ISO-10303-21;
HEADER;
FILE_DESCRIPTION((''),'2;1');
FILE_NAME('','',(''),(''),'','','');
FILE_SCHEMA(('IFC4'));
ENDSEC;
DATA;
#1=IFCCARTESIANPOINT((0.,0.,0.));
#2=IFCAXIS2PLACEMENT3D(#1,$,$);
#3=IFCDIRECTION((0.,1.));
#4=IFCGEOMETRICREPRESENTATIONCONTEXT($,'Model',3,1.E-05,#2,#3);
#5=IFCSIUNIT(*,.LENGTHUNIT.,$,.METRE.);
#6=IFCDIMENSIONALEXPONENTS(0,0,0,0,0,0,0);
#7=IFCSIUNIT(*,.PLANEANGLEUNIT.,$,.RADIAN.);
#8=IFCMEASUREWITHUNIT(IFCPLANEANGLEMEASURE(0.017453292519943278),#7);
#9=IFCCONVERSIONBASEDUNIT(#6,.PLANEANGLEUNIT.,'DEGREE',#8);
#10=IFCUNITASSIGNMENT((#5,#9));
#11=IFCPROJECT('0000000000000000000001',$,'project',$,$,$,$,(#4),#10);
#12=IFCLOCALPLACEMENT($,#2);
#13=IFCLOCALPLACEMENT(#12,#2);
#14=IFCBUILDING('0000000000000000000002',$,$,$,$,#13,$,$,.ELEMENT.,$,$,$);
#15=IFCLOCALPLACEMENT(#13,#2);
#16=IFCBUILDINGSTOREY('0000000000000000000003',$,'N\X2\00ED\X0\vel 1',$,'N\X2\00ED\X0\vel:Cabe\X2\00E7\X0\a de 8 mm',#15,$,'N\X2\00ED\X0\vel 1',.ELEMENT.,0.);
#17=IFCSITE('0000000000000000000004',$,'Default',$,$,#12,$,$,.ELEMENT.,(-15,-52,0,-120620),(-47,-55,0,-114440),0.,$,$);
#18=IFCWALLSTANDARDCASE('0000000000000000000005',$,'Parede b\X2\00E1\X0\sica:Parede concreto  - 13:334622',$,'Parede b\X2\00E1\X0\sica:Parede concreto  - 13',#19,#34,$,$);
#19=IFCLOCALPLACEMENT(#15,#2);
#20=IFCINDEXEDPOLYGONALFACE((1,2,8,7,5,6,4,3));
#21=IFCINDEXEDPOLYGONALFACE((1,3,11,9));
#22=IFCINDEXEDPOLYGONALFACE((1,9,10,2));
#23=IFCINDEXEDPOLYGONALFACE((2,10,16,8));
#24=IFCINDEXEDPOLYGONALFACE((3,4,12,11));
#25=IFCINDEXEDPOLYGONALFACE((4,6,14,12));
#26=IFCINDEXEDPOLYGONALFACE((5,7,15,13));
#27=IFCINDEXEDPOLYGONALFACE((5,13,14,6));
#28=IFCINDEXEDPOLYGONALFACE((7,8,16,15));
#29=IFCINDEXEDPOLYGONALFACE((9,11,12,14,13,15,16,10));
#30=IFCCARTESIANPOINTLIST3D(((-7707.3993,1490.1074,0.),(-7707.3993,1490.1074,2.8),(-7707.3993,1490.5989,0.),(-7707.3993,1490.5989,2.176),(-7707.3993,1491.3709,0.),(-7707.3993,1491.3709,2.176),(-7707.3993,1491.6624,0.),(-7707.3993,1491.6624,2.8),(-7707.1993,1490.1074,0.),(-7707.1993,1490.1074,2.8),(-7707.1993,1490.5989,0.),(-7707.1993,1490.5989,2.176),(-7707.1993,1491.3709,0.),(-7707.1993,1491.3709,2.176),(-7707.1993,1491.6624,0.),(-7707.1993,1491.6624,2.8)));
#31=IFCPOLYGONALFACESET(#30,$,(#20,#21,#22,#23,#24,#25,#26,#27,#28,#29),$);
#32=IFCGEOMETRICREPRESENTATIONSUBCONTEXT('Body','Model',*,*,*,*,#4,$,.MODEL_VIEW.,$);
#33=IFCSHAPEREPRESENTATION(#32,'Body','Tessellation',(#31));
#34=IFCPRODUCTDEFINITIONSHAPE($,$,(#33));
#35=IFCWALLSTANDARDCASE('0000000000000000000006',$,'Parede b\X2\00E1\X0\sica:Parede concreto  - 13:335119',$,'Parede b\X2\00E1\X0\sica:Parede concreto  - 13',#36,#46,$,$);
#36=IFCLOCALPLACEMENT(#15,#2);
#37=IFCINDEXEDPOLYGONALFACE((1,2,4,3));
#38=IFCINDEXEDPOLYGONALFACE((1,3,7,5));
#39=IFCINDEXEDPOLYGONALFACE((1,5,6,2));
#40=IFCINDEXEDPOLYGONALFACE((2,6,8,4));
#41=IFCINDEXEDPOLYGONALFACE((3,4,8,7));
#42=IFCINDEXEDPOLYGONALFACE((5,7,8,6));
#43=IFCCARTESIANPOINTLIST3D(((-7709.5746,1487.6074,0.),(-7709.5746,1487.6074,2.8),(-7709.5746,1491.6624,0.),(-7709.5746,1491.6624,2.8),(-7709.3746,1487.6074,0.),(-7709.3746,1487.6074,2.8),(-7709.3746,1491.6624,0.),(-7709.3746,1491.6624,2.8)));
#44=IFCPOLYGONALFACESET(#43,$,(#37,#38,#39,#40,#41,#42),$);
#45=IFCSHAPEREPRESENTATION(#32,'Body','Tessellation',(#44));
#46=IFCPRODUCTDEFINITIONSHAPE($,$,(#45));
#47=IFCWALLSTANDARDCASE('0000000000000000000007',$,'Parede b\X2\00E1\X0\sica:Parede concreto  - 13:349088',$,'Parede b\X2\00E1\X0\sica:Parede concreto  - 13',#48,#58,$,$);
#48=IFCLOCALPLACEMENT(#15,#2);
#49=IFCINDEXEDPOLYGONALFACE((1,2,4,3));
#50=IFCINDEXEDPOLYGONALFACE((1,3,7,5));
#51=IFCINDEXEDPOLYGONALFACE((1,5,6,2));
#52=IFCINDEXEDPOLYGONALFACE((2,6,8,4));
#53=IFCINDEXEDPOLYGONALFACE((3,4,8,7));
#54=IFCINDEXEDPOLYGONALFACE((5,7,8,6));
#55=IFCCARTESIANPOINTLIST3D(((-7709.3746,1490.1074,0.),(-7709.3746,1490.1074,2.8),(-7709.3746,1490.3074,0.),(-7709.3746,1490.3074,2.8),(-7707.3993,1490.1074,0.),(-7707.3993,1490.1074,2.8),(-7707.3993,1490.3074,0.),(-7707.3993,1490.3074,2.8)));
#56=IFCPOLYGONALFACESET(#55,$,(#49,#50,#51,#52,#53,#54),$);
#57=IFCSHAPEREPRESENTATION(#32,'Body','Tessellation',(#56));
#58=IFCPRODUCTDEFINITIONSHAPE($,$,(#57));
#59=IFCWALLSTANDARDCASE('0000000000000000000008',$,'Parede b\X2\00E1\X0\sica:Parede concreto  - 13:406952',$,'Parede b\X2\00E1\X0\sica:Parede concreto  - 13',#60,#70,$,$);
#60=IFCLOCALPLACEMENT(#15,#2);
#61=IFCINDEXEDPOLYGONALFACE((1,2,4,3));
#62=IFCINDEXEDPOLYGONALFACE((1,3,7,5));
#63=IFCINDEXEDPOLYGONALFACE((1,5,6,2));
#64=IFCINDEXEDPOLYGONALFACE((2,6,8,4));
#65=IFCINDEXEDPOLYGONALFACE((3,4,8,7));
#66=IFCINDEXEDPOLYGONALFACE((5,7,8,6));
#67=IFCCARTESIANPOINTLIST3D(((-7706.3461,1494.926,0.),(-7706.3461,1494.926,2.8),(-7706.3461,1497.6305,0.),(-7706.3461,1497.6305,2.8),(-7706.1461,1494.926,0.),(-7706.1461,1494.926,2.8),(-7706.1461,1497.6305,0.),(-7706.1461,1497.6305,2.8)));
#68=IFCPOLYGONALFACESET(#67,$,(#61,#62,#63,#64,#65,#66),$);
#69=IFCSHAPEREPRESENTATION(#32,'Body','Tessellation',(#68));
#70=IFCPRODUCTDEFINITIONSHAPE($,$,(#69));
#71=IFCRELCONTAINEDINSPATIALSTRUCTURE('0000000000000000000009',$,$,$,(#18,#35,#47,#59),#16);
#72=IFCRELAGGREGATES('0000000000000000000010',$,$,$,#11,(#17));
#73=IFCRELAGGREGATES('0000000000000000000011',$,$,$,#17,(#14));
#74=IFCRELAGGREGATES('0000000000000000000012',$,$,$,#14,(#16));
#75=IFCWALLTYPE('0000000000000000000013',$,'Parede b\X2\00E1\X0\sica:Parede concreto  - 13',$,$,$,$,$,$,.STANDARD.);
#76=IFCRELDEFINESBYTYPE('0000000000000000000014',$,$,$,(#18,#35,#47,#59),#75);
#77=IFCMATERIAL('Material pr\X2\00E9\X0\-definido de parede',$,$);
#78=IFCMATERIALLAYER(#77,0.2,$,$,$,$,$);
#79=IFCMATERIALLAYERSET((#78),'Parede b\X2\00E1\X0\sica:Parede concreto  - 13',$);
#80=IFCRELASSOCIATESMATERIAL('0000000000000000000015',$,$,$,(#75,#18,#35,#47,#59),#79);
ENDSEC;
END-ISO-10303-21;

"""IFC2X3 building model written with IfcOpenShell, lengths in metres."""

from ifc_helpers import new_model, entity, si_unit, converted_unit, direction, frame, frame_2d, origin, place, context, subcontext, project, spatial, rectangle, extrude, material, layer, layer_set, layer_usage, type_object, element, save


model = new_model("IFC2X3")

# Units and contexts
model_context = context("Model", 3, precision=1e-05, world=origin(), true_north=direction((0.0, 1.0)))
body_context = subcontext(model_context, "Body", "Model", "MODEL_VIEW")
ifc_project = project(units=[si_unit("LENGTHUNIT", "METRE"), converted_unit("PLANEANGLEUNIT", "DEGREE", entity("IfcPlaneAngleMeasure", 0.017453292519943278), si_unit("PLANEANGLEUNIT", "RADIAN"), dimensions=[0, 0, 0, 0, 0, 0, 0])], contexts=[model_context])

# Site, building, storey
site_placement = place(None, origin())
site = spatial("IfcSite", under=ifc_project, at=site_placement, Name="Default", CompositionType="ELEMENT", RefLatitude=(-15, -52, 0, -120620), RefLongitude=(-47, -55, 0, -114440), RefElevation=0.0)
building_placement = place(site_placement, origin())
building = spatial("IfcBuilding", under=site, at=building_placement, CompositionType="ELEMENT")
storey_placement = place(building_placement, origin())
storey = spatial("IfcBuildingStorey", under=building, at=storey_placement, Name="Nível 1", ObjectType="Nível:Cabeça de 8 mm", LongName="Nível 1", CompositionType="ELEMENT", Elevation=0.0)

# Shared definitions
ifc_material = material(Name="Material pré-definido de parede")
ifc_layer = layer(ifc_material, 0.2)
ifc_layer_set = layer_set([ifc_layer], Name="Parede básica:Parede concreto  - 13")
wall_type = type_object("IfcWallType", Name="Parede básica:Parede concreto  - 13", PredefinedType="STANDARD", material=ifc_layer_set)

# Wall, opening
ifc_layer_usage_1 = layer_usage(ifc_layer_set, "AXIS2", "POSITIVE", -0.1)
wall_1_placement = place(storey_placement, frame((-7707.2993, 1490.1074, 0.0), z_axis=(0.0, 0.0, 1.0), x_axis=(0.0, 1.0, 0.0)))
wall_1 = element("IfcWallStandardCase", 1, at=wall_1_placement, inside=storey, type_object=wall_type, material=ifc_layer_usage_1, Name="Parede básica:Parede concreto  - 13:334622", ObjectType="Parede básica:Parede concreto  - 13", context=body_context, shape_type="SweptSolid", body=[
    extrude(rectangle(XDim=1.555, YDim=0.2, at=frame_2d((0.7775, 0.0), x_axis=(-1.0, 0.0))), origin(), (0.0, 0.0, 1.0), 2.8),
])
opening_1_placement = place(wall_1_placement, origin())
element("IfcOpeningElement", 2, at=opening_1_placement, cuts=wall_1, ObjectType="Opening", context=body_context, shape_type="SweptSolid", body=[
    extrude(rectangle(XDim=2.176, YDim=0.772, at=frame_2d((0.0, 0.0), x_axis=(0.0, 1.0))), frame((0.8775, 0.1, 1.088), z_axis=(0.0, -1.0, 0.0), x_axis=(1.0, 0.0, 0.0)), (0.0, 0.0, 1.0), 0.2),
])

# Walls
ifc_layer_usage_2 = layer_usage(ifc_layer_set, "AXIS2", "POSITIVE", -0.1)
wall_2_placement = place(storey_placement, frame((-7709.4746, 1487.6074, 0.0), z_axis=(0.0, 0.0, 1.0), x_axis=(0.0, 1.0, 0.0)))
element("IfcWallStandardCase", 3, at=wall_2_placement, inside=storey, type_object=wall_type, material=ifc_layer_usage_2, Name="Parede básica:Parede concreto  - 13:335119", ObjectType="Parede básica:Parede concreto  - 13", context=body_context, shape_type="SweptSolid", body=[
    extrude(rectangle(XDim=4.055, YDim=0.2, at=frame_2d((2.0275, 0.0), x_axis=(-1.0, 0.0))), origin(), (0.0, 0.0, 1.0), 2.8),
])
ifc_layer_usage_3 = layer_usage(ifc_layer_set, "AXIS2", "NEGATIVE", 0.1)
wall_3_placement = place(storey_placement, frame((-7709.3746, 1490.2074, 0.0)))
element("IfcWallStandardCase", 4, at=wall_3_placement, inside=storey, type_object=wall_type, material=ifc_layer_usage_3, Name="Parede básica:Parede concreto  - 13:349088", ObjectType="Parede básica:Parede concreto  - 13", context=body_context, shape_type="SweptSolid", body=[
    extrude(rectangle(XDim=1.9753, YDim=0.2, at=frame_2d((0.9876, 0.0), x_axis=(-1.0, 0.0))), origin(), (0.0, 0.0, 1.0), 2.8),
])

# Wall
ifc_layer_usage_4 = layer_usage(ifc_layer_set, "AXIS2", "NEGATIVE", 0.1)
wall_4_placement = place(storey_placement, frame((-7706.2461, 1497.6305, 0.0), z_axis=(0.0, 0.0, 1.0), x_axis=(0.0, -1.0, 0.0)))
element("IfcWallStandardCase", 5, at=wall_4_placement, inside=storey, type_object=wall_type, material=ifc_layer_usage_4, Name="Parede básica:Parede concreto  - 13:406952", ObjectType="Parede básica:Parede concreto  - 13", context=body_context, shape_type="SweptSolid", body=[
    extrude(rectangle(XDim=2.7045, YDim=0.2, at=frame_2d((1.3522, 0.0), x_axis=(-1.0, 0.0))), origin(), (0.0, 0.0, 1.0), 2.8),
])

save(model, "model.ifc")
